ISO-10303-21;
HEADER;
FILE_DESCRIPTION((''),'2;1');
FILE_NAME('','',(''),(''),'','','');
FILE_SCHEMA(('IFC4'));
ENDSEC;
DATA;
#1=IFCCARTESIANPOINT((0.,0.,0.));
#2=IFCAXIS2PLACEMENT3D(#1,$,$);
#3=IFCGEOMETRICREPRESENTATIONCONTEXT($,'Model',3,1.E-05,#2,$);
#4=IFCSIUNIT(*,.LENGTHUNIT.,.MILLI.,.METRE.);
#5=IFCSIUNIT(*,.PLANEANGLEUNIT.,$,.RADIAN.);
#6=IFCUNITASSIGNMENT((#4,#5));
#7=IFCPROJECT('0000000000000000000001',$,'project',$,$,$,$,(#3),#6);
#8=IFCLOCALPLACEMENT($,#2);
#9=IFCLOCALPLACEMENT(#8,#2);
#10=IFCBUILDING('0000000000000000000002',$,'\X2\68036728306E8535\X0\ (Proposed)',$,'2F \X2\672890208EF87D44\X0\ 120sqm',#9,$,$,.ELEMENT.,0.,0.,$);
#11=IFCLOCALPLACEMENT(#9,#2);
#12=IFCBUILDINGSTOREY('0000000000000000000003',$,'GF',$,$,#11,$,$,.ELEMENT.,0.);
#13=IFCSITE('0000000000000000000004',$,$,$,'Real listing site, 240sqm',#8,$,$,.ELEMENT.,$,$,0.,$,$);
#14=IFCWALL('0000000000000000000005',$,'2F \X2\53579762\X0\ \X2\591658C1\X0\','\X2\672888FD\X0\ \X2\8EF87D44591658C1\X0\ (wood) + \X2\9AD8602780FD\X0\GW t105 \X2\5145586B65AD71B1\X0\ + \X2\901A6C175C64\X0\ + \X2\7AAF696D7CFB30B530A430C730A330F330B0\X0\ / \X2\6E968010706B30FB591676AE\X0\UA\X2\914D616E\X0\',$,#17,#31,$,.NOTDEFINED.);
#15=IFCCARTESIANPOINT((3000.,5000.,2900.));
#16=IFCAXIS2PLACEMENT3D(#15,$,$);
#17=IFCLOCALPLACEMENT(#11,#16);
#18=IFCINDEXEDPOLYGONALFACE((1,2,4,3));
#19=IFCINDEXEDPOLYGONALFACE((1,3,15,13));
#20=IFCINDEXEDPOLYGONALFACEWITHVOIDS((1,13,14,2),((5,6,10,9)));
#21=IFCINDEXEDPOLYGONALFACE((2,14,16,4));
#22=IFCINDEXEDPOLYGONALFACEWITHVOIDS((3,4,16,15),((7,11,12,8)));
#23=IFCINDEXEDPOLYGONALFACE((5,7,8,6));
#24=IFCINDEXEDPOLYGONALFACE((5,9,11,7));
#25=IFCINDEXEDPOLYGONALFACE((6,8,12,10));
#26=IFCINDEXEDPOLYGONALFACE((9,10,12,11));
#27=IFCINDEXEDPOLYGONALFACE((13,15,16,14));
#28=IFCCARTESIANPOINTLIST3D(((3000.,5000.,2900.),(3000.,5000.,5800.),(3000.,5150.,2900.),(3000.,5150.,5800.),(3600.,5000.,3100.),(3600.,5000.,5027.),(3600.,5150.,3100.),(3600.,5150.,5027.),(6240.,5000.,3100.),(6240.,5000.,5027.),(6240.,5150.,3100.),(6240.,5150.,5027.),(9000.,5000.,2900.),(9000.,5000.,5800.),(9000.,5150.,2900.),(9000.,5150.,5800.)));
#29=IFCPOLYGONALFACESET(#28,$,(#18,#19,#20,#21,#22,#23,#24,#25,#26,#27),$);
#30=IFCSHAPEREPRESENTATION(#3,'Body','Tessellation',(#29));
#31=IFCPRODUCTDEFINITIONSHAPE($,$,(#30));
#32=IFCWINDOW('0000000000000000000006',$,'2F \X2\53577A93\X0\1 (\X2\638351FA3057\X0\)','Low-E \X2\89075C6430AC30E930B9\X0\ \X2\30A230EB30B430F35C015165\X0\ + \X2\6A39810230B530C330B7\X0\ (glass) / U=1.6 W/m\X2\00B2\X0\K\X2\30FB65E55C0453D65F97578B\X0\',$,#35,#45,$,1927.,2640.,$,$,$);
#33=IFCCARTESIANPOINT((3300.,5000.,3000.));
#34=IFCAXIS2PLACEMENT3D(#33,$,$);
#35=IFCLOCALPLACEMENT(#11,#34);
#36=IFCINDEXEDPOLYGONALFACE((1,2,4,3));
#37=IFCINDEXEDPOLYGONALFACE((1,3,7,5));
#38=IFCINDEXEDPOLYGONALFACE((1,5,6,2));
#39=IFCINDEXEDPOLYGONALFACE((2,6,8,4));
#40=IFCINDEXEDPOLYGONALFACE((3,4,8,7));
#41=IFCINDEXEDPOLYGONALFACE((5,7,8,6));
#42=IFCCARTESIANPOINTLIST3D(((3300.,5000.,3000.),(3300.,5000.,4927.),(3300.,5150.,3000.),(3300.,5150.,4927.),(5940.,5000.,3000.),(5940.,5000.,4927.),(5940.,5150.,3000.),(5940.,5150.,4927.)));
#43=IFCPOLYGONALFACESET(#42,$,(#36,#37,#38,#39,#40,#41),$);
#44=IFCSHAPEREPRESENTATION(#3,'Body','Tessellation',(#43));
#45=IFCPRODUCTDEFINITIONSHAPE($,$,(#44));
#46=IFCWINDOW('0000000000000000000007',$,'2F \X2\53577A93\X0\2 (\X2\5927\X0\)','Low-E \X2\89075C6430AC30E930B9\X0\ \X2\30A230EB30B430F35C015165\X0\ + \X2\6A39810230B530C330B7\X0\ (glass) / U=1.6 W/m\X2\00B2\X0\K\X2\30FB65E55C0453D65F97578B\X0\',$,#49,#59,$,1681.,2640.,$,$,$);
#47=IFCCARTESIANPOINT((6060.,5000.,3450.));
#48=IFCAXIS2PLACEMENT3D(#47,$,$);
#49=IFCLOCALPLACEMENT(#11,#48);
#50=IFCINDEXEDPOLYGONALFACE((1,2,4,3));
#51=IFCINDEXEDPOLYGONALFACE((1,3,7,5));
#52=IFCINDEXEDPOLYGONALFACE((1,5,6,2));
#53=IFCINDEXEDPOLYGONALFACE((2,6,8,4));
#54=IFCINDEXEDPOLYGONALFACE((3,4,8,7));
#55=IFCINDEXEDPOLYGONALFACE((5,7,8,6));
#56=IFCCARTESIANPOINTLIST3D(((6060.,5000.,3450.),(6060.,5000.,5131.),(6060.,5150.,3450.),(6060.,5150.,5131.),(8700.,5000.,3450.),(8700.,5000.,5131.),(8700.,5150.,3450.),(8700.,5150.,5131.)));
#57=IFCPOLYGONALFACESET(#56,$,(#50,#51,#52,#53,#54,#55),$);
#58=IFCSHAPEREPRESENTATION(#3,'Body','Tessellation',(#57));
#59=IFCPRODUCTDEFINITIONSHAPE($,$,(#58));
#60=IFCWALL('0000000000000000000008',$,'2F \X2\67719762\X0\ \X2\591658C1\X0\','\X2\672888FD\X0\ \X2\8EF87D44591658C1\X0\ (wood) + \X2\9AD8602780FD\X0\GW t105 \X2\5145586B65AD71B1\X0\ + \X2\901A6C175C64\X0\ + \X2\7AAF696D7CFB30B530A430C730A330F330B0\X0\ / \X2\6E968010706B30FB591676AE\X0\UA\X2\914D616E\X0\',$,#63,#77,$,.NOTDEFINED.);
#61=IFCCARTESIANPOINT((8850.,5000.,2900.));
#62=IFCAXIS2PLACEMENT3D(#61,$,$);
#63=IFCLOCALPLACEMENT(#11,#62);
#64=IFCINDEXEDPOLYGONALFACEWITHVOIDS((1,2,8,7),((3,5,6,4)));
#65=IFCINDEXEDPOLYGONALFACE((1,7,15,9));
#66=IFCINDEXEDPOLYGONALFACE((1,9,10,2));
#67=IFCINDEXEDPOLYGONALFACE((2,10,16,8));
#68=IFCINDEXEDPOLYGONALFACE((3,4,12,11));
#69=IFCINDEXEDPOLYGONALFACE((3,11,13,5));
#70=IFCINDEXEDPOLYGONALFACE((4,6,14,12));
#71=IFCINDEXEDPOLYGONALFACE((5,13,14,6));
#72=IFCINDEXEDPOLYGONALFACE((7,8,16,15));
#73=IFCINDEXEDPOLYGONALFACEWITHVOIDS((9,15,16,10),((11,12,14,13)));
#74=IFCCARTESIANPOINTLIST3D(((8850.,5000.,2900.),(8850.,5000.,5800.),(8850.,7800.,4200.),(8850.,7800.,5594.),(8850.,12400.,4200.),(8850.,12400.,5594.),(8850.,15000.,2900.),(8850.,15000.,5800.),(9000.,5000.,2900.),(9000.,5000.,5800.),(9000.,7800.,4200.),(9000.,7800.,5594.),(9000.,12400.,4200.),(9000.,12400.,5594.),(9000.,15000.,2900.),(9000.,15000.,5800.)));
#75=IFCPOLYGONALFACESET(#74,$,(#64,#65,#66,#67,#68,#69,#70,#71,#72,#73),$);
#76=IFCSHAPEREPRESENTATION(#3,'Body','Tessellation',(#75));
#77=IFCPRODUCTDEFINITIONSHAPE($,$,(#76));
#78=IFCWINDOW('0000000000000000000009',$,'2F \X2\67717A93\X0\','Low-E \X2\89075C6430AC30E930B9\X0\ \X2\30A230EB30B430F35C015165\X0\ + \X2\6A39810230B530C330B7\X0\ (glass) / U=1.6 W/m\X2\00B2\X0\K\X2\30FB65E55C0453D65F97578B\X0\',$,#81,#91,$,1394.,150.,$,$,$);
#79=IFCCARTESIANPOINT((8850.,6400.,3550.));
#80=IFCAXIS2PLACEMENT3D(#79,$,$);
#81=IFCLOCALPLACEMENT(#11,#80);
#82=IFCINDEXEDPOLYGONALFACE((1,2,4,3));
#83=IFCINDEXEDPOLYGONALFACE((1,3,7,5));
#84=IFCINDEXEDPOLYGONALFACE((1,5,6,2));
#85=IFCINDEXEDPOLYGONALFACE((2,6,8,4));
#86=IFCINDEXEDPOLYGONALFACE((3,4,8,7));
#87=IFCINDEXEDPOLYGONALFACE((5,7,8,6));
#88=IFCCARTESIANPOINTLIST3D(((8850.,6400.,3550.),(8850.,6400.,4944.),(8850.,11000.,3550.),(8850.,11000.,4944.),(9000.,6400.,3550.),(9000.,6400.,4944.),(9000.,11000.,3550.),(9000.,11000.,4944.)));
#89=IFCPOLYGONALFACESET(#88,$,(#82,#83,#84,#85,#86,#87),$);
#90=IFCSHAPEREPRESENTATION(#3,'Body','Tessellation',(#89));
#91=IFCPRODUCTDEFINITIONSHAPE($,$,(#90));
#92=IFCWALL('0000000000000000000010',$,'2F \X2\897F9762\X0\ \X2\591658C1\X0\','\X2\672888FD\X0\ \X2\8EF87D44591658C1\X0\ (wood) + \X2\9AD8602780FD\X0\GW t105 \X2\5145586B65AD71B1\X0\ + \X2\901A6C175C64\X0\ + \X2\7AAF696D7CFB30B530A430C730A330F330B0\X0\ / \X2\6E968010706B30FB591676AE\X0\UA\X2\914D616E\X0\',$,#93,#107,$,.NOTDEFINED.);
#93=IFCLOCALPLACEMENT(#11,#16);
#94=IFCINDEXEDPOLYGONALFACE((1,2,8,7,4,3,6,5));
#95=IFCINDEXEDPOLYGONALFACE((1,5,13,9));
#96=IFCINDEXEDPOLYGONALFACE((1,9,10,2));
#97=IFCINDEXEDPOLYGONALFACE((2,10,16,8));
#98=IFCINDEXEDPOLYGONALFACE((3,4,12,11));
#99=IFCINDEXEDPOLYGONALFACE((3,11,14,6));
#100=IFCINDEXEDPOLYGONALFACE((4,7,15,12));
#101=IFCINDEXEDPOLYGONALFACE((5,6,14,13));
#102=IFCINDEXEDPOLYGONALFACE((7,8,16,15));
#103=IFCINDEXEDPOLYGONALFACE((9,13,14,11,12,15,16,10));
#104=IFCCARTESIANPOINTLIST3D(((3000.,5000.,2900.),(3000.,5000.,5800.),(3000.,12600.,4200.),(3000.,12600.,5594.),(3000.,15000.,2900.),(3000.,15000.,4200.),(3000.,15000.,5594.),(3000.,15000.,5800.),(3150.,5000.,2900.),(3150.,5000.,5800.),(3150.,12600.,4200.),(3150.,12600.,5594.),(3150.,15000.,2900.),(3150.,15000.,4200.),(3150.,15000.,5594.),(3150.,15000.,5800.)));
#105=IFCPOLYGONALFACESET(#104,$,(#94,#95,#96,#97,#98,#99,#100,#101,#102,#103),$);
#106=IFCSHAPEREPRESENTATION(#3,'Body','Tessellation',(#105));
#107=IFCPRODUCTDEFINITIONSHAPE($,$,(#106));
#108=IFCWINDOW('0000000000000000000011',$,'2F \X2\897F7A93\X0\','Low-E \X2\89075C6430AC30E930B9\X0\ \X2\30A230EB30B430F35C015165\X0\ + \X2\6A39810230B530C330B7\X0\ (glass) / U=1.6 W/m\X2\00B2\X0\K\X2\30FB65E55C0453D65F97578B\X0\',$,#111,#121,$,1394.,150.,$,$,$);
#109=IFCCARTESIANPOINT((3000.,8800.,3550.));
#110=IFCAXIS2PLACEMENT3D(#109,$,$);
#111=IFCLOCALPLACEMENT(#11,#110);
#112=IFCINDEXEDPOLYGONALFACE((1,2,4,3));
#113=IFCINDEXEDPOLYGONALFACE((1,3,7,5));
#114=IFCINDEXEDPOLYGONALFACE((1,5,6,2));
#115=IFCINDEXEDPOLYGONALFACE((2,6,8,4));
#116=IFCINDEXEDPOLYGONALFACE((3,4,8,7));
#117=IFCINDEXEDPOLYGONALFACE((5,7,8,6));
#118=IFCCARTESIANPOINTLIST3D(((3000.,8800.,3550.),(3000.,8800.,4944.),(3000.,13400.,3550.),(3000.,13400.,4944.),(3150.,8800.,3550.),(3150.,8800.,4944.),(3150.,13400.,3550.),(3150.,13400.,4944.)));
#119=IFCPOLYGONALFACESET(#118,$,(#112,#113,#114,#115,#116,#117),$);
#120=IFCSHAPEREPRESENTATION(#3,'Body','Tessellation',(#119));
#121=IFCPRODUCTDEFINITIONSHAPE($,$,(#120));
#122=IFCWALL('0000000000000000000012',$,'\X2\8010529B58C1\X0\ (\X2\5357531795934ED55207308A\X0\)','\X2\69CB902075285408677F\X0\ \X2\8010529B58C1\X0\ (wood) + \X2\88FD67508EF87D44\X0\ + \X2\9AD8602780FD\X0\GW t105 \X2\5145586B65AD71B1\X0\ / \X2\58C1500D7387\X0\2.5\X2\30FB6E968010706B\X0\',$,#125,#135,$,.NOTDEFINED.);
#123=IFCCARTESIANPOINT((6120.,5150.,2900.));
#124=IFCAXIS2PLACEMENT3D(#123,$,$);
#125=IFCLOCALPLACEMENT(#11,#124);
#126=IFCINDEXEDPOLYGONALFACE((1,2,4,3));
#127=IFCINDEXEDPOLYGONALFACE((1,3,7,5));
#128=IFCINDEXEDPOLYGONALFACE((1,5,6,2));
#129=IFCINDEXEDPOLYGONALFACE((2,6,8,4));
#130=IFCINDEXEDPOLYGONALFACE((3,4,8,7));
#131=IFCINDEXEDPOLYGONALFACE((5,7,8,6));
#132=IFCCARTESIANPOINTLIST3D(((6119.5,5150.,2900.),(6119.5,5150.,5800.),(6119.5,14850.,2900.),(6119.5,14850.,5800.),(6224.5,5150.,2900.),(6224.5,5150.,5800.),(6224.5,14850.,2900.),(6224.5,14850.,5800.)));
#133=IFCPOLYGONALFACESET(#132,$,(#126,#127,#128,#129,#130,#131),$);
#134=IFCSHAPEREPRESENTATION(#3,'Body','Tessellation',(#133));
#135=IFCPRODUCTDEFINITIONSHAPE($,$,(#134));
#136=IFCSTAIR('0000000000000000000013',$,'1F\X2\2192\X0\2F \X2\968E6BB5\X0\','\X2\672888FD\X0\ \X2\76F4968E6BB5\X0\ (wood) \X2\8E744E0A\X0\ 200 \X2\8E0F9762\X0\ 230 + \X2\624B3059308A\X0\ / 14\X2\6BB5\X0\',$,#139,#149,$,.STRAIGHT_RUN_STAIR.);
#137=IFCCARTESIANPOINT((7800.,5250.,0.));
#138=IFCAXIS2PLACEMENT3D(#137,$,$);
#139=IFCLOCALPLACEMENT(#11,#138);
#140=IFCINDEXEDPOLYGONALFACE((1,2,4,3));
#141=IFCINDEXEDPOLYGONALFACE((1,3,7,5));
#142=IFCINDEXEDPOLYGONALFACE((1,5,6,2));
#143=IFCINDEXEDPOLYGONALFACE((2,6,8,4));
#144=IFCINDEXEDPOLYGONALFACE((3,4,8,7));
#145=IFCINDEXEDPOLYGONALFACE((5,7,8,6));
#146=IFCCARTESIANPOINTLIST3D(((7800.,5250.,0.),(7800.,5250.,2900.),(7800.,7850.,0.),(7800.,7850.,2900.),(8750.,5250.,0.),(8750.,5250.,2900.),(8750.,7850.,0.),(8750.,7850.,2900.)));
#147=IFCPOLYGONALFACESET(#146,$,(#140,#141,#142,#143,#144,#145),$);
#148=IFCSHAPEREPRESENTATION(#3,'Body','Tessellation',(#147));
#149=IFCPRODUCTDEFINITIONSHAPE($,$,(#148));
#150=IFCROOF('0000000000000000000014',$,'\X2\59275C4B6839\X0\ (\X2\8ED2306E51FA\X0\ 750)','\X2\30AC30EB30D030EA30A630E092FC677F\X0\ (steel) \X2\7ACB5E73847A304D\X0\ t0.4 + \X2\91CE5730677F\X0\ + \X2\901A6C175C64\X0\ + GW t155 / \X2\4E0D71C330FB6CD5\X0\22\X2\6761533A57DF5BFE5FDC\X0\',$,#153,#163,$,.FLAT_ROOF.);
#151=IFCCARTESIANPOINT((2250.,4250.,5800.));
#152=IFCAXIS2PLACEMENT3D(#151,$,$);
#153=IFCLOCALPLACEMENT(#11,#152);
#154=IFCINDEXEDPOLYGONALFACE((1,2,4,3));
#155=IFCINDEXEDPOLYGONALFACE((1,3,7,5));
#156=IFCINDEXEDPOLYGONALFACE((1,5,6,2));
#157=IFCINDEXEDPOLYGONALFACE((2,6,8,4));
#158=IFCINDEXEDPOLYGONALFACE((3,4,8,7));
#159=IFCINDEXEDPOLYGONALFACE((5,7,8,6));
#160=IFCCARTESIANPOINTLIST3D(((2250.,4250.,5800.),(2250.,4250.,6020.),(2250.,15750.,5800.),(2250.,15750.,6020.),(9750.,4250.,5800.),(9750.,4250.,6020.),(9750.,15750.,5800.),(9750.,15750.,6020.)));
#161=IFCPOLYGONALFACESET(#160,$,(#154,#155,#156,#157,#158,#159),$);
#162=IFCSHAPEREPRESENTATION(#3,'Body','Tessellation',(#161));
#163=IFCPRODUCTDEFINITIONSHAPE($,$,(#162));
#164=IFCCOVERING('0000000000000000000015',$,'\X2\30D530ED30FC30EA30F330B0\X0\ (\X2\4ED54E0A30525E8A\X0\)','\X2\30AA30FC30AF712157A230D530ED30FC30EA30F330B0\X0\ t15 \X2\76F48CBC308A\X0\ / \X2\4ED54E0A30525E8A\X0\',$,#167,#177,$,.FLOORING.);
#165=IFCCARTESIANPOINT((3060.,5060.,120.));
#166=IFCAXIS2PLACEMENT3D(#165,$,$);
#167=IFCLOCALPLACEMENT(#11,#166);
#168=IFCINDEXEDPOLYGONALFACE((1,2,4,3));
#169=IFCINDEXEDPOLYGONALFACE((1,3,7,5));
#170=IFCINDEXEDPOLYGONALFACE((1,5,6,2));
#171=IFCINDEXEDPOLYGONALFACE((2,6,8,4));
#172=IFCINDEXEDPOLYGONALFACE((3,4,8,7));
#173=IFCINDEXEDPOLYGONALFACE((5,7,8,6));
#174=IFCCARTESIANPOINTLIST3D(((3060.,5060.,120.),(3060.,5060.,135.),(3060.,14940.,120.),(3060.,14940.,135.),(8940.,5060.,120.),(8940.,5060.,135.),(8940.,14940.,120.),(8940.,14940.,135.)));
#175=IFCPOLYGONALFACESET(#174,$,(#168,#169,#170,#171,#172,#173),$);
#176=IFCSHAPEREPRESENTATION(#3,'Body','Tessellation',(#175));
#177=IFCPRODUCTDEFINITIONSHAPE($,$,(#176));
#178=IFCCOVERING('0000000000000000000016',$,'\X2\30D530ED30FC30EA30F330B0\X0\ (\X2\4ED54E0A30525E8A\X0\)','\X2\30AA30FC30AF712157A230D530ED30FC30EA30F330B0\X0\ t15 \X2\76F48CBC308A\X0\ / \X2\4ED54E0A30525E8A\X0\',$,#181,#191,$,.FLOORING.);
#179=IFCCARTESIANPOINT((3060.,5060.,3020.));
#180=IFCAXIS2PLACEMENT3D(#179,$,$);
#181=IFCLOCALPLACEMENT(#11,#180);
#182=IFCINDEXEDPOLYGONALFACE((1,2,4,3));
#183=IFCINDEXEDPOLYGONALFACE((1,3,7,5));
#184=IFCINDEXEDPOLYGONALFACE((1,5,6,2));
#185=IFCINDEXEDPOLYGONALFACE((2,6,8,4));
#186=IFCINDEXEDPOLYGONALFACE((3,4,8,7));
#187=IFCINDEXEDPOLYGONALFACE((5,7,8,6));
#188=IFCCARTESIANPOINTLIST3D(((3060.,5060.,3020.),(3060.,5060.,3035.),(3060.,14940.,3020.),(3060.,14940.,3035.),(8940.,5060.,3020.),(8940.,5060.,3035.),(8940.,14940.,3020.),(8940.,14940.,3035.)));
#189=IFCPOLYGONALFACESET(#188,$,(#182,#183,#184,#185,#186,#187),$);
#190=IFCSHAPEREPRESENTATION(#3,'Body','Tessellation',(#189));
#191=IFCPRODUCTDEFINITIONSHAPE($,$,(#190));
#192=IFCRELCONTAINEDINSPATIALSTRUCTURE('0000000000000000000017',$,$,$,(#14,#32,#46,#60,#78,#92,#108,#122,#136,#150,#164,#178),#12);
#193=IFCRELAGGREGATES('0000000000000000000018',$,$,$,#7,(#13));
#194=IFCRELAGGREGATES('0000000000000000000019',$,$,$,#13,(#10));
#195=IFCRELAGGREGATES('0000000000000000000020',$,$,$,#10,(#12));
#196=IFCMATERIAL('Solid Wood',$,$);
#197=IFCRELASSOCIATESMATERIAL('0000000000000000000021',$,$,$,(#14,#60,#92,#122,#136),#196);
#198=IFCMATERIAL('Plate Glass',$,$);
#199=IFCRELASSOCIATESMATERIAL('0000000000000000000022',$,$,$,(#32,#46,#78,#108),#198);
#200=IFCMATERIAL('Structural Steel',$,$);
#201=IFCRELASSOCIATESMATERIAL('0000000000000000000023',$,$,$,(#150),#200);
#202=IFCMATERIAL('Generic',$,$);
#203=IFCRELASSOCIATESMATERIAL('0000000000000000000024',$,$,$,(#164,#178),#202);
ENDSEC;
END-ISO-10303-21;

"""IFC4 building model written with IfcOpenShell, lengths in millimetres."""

from ifc_helpers import new_model, si_unit, frame, frame_2d, origin, place, context, project, spatial, rectangle, extrude, material, element, fill, save


model = new_model("IFC4")

# Units and contexts
model_context = context("Model", 3, precision=1e-05, world=origin())
ifc_project = project(units=[si_unit("LENGTHUNIT", "METRE", prefix="MILLI"), si_unit("PLANEANGLEUNIT", "RADIAN")], contexts=[model_context])

# Site, building, storey
site_placement = place(None, origin())
site = spatial("IfcSite", under=ifc_project, at=site_placement, ObjectType="Real listing site, 240sqm", CompositionType="ELEMENT", RefElevation=0.0)
building_placement = place(site_placement, origin())
building = spatial("IfcBuilding", under=site, at=building_placement, Name="栃木の蔵 (Proposed)", ObjectType="2F 木造軸組 120sqm", CompositionType="ELEMENT", ElevationOfRefHeight=0.0, ElevationOfTerrain=0.0)
storey_placement = place(building_placement, origin())
storey = spatial("IfcBuildingStorey", under=building, at=storey_placement, Name="GF", CompositionType="ELEMENT", Elevation=0.0)

# Shared definitions
ifc_material_1 = material(Name="Solid Wood")

# Shared definitions
ifc_material_2 = material(Name="Plate Glass")

# Wall, openings, windows
wall_1_placement = place(storey_placement, frame((3000.0, 5000.0, 2900.0)))
wall_1 = element("IfcWall", 1, at=wall_1_placement, inside=storey, material=ifc_material_1, Name="2F 南面 外壁", Description="木製 軸組外壁 (wood) + 高性能GW t105 充填断熱 + 通気層 + 窯業系サイディング / 準耐火・外皮UA配慮", PredefinedType="NOTDEFINED", context=model_context, shape_type="SweptSolid", body=[
    extrude(rectangle(XDim=6000.0, YDim=150.0, at=frame_2d((3000.0, 75.0))), frame((3000.0, 5000.0, 2900.0)), (0.0, 0.0, 1.0), 2900.0),
])
opening_1_placement = place(storey_placement, frame((3300.0, 5000.0, 3000.0)))
opening_1 = element("IfcOpeningElement", 2, at=opening_1_placement, cuts=wall_1, PredefinedType="NOTDEFINED", context=model_context, shape_type="SweptSolid", body=[
    extrude(rectangle(XDim=2640.0, YDim=150.0, at=frame_2d((1320.0, 75.0))), frame((3300.0, 5000.0, 3000.0)), (0.0, 0.0, 1.0), 1927.0),
])
opening_2_placement = place(storey_placement, frame((6060.0, 5000.0, 3450.0)))
opening_2 = element("IfcOpeningElement", 3, at=opening_2_placement, cuts=wall_1, PredefinedType="NOTDEFINED", context=model_context, shape_type="SweptSolid", body=[
    extrude(rectangle(XDim=2640.0, YDim=150.0, at=frame_2d((1320.0, 75.0))), frame((6060.0, 5000.0, 3450.0)), (0.0, 0.0, 1.0), 1681.0),
])
window_1_placement = place(storey_placement, frame((3300.0, 5000.0, 3000.0)))
window_1 = element("IfcWindow", 4, at=window_1_placement, inside=storey, material=ifc_material_2, Name="2F 南窓1 (掃出し)", Description="Low-E 複層ガラス アルゴン封入 + 樹脂サッシ (glass) / U=1.6 W/m²K・日射取得型", OverallHeight=1927.0, OverallWidth=2640.0, context=model_context, shape_type="SweptSolid", body=[
    extrude(rectangle(XDim=2640.0, YDim=150.0, at=frame_2d((1320.0, 75.0))), frame((3300.0, 5000.0, 3000.0)), (0.0, 0.0, 1.0), 1927.0),
])
fill(opening_1, window_1)
window_2_placement = place(storey_placement, frame((6060.0, 5000.0, 3450.0)))
window_2 = element("IfcWindow", 5, at=window_2_placement, inside=storey, material=ifc_material_2, Name="2F 南窓2 (大)", Description="Low-E 複層ガラス アルゴン封入 + 樹脂サッシ (glass) / U=1.6 W/m²K・日射取得型", OverallHeight=1681.0, OverallWidth=2640.0, context=model_context, shape_type="SweptSolid", body=[
    extrude(rectangle(XDim=2640.0, YDim=150.0, at=frame_2d((1320.0, 75.0))), frame((6060.0, 5000.0, 3450.0)), (0.0, 0.0, 1.0), 1681.0),
])
fill(opening_2, window_2)

# Walls, openings, windows
wall_2_placement = place(storey_placement, frame((8850.0, 5000.0, 2900.0)))
wall_2 = element("IfcWall", 6, at=wall_2_placement, inside=storey, material=ifc_material_1, Name="2F 東面 外壁", Description="木製 軸組外壁 (wood) + 高性能GW t105 充填断熱 + 通気層 + 窯業系サイディング / 準耐火・外皮UA配慮", PredefinedType="NOTDEFINED", context=model_context, shape_type="SweptSolid", body=[
    extrude(rectangle(XDim=150.0, YDim=10000.0, at=frame_2d((75.0, 5000.0))), frame((8850.0, 5000.0, 2900.0)), (0.0, 0.0, 1.0), 2900.0),
])
opening_3_placement = place(storey_placement, frame((8850.0, 6400.0, 3550.0)))
opening_3 = element("IfcOpeningElement", 7, at=opening_3_placement, cuts=wall_2, PredefinedType="NOTDEFINED", context=model_context, shape_type="SweptSolid", body=[
    extrude(rectangle(XDim=150.0, YDim=4600.0, at=frame_2d((75.0, 2300.0))), frame((8850.0, 6400.0, 3550.0)), (0.0, 0.0, 1.0), 1394.0),
])
window_3_placement = place(storey_placement, frame((8850.0, 6400.0, 3550.0)))
window_3 = element("IfcWindow", 8, at=window_3_placement, inside=storey, material=ifc_material_2, Name="2F 東窓", Description="Low-E 複層ガラス アルゴン封入 + 樹脂サッシ (glass) / U=1.6 W/m²K・日射取得型", OverallHeight=1394.0, OverallWidth=150.0, context=model_context, shape_type="SweptSolid", body=[
    extrude(rectangle(XDim=150.0, YDim=4600.0, at=frame_2d((75.0, 2300.0))), frame((8850.0, 6400.0, 3550.0)), (0.0, 0.0, 1.0), 1394.0),
])
fill(opening_3, window_3)
wall_3_placement = place(storey_placement, frame((3000.0, 5000.0, 2900.0)))
wall_3 = element("IfcWall", 9, at=wall_3_placement, inside=storey, material=ifc_material_1, Name="2F 西面 外壁", Description="木製 軸組外壁 (wood) + 高性能GW t105 充填断熱 + 通気層 + 窯業系サイディング / 準耐火・外皮UA配慮", PredefinedType="NOTDEFINED", context=model_context, shape_type="SweptSolid", body=[
    extrude(rectangle(XDim=150.0, YDim=10000.0, at=frame_2d((75.0, 5000.0))), frame((3000.0, 5000.0, 2900.0)), (0.0, 0.0, 1.0), 2900.0),
])
opening_4_placement = place(storey_placement, frame((3000.0, 8800.0, 3550.0)))
opening_4 = element("IfcOpeningElement", 10, at=opening_4_placement, cuts=wall_3, PredefinedType="NOTDEFINED", context=model_context, shape_type="SweptSolid", body=[
    extrude(rectangle(XDim=150.0, YDim=4600.0, at=frame_2d((75.0, 2300.0))), frame((3000.0, 8800.0, 3550.0)), (0.0, 0.0, 1.0), 1394.0),
])
window_4_placement = place(storey_placement, frame((3000.0, 8800.0, 3550.0)))
window_4 = element("IfcWindow", 11, at=window_4_placement, inside=storey, material=ifc_material_2, Name="2F 西窓", Description="Low-E 複層ガラス アルゴン封入 + 樹脂サッシ (glass) / U=1.6 W/m²K・日射取得型", OverallHeight=1394.0, OverallWidth=150.0, context=model_context, shape_type="SweptSolid", body=[
    extrude(rectangle(XDim=150.0, YDim=4600.0, at=frame_2d((75.0, 2300.0))), frame((3000.0, 8800.0, 3550.0)), (0.0, 0.0, 1.0), 1394.0),
])
fill(opening_4, window_4)

# Wall
wall_4_placement = place(storey_placement, frame((6120.0, 5150.0, 2900.0)))
element("IfcWall", 12, at=wall_4_placement, inside=storey, material=ifc_material_1, Name="耐力壁 (南北間仕切り)", Description="構造用合板 耐力壁 (wood) + 製材軸組 + 高性能GW t105 充填断熱 / 壁倍率2.5・準耐火", PredefinedType="NOTDEFINED", context=model_context, shape_type="SweptSolid", body=[
    extrude(rectangle(XDim=105.0, YDim=9700.0, at=frame_2d((52.0, 4850.0))), frame((6120.0, 5150.0, 2900.0)), (0.0, 0.0, 1.0), 2900.0),
])

# Stair
stair_placement = place(storey_placement, frame((7800.0, 5250.0, 0.0)))
element("IfcStair", 13, at=stair_placement, inside=storey, material=ifc_material_1, Name="1F→2F 階段", Description="木製 直階段 (wood) 蹴上 200 踏面 230 + 手すり / 14段", PredefinedType="STRAIGHT_RUN_STAIR", context=model_context, shape_type="SweptSolid", body=[
    extrude(rectangle(XDim=950.0, YDim=2600.0, at=frame_2d((475.0, 1300.0))), frame((7800.0, 5250.0, 0.0)), (0.0, 0.0, 1.0), 2900.0),
])

# Roof
ifc_material_3 = material(Name="Structural Steel")
roof_placement = place(storey_placement, frame((2250.0, 4250.0, 5800.0)))
element("IfcRoof", 14, at=roof_placement, inside=storey, material=ifc_material_3, Name="大屋根 (軒の出 750)", Description="ガルバリウム鋼板 (steel) 立平葺き t0.4 + 野地板 + 通気層 + GW t155 / 不燃・法22条区域対応", PredefinedType="FLAT_ROOF", context=model_context, shape_type="SweptSolid", body=[
    extrude(rectangle(XDim=7500.0, YDim=11500.0, at=frame_2d((3750.0, 5750.0))), frame((2250.0, 4250.0, 5800.0)), (0.0, 0.0, 1.0), 220.0),
])

# Coverings
ifc_material_4 = material(Name="Generic")
covering_1_placement = place(storey_placement, frame((3060.0, 5060.0, 120.0)))
element("IfcCovering", 15, at=covering_1_placement, inside=storey, material=ifc_material_4, Name="フローリング (仕上げ床)", Description="オーク無垢フローリング t15 直貼り / 仕上げ床", PredefinedType="FLOORING", context=model_context, shape_type="SweptSolid", body=[
    extrude(rectangle(XDim=5880.0, YDim=9880.0, at=frame_2d((2940.0, 4940.0))), frame((3060.0, 5060.0, 120.0)), (0.0, 0.0, 1.0), 15.0),
])
covering_2_placement = place(storey_placement, frame((3060.0, 5060.0, 3020.0)))
element("IfcCovering", 16, at=covering_2_placement, inside=storey, material=ifc_material_4, Name="フローリング (仕上げ床)", Description="オーク無垢フローリング t15 直貼り / 仕上げ床", PredefinedType="FLOORING", context=model_context, shape_type="SweptSolid", body=[
    extrude(rectangle(XDim=5880.0, YDim=9880.0, at=frame_2d((2940.0, 4940.0))), frame((3060.0, 5060.0, 3020.0)), (0.0, 0.0, 1.0), 15.0),
])

save(model, "model.ifc")
